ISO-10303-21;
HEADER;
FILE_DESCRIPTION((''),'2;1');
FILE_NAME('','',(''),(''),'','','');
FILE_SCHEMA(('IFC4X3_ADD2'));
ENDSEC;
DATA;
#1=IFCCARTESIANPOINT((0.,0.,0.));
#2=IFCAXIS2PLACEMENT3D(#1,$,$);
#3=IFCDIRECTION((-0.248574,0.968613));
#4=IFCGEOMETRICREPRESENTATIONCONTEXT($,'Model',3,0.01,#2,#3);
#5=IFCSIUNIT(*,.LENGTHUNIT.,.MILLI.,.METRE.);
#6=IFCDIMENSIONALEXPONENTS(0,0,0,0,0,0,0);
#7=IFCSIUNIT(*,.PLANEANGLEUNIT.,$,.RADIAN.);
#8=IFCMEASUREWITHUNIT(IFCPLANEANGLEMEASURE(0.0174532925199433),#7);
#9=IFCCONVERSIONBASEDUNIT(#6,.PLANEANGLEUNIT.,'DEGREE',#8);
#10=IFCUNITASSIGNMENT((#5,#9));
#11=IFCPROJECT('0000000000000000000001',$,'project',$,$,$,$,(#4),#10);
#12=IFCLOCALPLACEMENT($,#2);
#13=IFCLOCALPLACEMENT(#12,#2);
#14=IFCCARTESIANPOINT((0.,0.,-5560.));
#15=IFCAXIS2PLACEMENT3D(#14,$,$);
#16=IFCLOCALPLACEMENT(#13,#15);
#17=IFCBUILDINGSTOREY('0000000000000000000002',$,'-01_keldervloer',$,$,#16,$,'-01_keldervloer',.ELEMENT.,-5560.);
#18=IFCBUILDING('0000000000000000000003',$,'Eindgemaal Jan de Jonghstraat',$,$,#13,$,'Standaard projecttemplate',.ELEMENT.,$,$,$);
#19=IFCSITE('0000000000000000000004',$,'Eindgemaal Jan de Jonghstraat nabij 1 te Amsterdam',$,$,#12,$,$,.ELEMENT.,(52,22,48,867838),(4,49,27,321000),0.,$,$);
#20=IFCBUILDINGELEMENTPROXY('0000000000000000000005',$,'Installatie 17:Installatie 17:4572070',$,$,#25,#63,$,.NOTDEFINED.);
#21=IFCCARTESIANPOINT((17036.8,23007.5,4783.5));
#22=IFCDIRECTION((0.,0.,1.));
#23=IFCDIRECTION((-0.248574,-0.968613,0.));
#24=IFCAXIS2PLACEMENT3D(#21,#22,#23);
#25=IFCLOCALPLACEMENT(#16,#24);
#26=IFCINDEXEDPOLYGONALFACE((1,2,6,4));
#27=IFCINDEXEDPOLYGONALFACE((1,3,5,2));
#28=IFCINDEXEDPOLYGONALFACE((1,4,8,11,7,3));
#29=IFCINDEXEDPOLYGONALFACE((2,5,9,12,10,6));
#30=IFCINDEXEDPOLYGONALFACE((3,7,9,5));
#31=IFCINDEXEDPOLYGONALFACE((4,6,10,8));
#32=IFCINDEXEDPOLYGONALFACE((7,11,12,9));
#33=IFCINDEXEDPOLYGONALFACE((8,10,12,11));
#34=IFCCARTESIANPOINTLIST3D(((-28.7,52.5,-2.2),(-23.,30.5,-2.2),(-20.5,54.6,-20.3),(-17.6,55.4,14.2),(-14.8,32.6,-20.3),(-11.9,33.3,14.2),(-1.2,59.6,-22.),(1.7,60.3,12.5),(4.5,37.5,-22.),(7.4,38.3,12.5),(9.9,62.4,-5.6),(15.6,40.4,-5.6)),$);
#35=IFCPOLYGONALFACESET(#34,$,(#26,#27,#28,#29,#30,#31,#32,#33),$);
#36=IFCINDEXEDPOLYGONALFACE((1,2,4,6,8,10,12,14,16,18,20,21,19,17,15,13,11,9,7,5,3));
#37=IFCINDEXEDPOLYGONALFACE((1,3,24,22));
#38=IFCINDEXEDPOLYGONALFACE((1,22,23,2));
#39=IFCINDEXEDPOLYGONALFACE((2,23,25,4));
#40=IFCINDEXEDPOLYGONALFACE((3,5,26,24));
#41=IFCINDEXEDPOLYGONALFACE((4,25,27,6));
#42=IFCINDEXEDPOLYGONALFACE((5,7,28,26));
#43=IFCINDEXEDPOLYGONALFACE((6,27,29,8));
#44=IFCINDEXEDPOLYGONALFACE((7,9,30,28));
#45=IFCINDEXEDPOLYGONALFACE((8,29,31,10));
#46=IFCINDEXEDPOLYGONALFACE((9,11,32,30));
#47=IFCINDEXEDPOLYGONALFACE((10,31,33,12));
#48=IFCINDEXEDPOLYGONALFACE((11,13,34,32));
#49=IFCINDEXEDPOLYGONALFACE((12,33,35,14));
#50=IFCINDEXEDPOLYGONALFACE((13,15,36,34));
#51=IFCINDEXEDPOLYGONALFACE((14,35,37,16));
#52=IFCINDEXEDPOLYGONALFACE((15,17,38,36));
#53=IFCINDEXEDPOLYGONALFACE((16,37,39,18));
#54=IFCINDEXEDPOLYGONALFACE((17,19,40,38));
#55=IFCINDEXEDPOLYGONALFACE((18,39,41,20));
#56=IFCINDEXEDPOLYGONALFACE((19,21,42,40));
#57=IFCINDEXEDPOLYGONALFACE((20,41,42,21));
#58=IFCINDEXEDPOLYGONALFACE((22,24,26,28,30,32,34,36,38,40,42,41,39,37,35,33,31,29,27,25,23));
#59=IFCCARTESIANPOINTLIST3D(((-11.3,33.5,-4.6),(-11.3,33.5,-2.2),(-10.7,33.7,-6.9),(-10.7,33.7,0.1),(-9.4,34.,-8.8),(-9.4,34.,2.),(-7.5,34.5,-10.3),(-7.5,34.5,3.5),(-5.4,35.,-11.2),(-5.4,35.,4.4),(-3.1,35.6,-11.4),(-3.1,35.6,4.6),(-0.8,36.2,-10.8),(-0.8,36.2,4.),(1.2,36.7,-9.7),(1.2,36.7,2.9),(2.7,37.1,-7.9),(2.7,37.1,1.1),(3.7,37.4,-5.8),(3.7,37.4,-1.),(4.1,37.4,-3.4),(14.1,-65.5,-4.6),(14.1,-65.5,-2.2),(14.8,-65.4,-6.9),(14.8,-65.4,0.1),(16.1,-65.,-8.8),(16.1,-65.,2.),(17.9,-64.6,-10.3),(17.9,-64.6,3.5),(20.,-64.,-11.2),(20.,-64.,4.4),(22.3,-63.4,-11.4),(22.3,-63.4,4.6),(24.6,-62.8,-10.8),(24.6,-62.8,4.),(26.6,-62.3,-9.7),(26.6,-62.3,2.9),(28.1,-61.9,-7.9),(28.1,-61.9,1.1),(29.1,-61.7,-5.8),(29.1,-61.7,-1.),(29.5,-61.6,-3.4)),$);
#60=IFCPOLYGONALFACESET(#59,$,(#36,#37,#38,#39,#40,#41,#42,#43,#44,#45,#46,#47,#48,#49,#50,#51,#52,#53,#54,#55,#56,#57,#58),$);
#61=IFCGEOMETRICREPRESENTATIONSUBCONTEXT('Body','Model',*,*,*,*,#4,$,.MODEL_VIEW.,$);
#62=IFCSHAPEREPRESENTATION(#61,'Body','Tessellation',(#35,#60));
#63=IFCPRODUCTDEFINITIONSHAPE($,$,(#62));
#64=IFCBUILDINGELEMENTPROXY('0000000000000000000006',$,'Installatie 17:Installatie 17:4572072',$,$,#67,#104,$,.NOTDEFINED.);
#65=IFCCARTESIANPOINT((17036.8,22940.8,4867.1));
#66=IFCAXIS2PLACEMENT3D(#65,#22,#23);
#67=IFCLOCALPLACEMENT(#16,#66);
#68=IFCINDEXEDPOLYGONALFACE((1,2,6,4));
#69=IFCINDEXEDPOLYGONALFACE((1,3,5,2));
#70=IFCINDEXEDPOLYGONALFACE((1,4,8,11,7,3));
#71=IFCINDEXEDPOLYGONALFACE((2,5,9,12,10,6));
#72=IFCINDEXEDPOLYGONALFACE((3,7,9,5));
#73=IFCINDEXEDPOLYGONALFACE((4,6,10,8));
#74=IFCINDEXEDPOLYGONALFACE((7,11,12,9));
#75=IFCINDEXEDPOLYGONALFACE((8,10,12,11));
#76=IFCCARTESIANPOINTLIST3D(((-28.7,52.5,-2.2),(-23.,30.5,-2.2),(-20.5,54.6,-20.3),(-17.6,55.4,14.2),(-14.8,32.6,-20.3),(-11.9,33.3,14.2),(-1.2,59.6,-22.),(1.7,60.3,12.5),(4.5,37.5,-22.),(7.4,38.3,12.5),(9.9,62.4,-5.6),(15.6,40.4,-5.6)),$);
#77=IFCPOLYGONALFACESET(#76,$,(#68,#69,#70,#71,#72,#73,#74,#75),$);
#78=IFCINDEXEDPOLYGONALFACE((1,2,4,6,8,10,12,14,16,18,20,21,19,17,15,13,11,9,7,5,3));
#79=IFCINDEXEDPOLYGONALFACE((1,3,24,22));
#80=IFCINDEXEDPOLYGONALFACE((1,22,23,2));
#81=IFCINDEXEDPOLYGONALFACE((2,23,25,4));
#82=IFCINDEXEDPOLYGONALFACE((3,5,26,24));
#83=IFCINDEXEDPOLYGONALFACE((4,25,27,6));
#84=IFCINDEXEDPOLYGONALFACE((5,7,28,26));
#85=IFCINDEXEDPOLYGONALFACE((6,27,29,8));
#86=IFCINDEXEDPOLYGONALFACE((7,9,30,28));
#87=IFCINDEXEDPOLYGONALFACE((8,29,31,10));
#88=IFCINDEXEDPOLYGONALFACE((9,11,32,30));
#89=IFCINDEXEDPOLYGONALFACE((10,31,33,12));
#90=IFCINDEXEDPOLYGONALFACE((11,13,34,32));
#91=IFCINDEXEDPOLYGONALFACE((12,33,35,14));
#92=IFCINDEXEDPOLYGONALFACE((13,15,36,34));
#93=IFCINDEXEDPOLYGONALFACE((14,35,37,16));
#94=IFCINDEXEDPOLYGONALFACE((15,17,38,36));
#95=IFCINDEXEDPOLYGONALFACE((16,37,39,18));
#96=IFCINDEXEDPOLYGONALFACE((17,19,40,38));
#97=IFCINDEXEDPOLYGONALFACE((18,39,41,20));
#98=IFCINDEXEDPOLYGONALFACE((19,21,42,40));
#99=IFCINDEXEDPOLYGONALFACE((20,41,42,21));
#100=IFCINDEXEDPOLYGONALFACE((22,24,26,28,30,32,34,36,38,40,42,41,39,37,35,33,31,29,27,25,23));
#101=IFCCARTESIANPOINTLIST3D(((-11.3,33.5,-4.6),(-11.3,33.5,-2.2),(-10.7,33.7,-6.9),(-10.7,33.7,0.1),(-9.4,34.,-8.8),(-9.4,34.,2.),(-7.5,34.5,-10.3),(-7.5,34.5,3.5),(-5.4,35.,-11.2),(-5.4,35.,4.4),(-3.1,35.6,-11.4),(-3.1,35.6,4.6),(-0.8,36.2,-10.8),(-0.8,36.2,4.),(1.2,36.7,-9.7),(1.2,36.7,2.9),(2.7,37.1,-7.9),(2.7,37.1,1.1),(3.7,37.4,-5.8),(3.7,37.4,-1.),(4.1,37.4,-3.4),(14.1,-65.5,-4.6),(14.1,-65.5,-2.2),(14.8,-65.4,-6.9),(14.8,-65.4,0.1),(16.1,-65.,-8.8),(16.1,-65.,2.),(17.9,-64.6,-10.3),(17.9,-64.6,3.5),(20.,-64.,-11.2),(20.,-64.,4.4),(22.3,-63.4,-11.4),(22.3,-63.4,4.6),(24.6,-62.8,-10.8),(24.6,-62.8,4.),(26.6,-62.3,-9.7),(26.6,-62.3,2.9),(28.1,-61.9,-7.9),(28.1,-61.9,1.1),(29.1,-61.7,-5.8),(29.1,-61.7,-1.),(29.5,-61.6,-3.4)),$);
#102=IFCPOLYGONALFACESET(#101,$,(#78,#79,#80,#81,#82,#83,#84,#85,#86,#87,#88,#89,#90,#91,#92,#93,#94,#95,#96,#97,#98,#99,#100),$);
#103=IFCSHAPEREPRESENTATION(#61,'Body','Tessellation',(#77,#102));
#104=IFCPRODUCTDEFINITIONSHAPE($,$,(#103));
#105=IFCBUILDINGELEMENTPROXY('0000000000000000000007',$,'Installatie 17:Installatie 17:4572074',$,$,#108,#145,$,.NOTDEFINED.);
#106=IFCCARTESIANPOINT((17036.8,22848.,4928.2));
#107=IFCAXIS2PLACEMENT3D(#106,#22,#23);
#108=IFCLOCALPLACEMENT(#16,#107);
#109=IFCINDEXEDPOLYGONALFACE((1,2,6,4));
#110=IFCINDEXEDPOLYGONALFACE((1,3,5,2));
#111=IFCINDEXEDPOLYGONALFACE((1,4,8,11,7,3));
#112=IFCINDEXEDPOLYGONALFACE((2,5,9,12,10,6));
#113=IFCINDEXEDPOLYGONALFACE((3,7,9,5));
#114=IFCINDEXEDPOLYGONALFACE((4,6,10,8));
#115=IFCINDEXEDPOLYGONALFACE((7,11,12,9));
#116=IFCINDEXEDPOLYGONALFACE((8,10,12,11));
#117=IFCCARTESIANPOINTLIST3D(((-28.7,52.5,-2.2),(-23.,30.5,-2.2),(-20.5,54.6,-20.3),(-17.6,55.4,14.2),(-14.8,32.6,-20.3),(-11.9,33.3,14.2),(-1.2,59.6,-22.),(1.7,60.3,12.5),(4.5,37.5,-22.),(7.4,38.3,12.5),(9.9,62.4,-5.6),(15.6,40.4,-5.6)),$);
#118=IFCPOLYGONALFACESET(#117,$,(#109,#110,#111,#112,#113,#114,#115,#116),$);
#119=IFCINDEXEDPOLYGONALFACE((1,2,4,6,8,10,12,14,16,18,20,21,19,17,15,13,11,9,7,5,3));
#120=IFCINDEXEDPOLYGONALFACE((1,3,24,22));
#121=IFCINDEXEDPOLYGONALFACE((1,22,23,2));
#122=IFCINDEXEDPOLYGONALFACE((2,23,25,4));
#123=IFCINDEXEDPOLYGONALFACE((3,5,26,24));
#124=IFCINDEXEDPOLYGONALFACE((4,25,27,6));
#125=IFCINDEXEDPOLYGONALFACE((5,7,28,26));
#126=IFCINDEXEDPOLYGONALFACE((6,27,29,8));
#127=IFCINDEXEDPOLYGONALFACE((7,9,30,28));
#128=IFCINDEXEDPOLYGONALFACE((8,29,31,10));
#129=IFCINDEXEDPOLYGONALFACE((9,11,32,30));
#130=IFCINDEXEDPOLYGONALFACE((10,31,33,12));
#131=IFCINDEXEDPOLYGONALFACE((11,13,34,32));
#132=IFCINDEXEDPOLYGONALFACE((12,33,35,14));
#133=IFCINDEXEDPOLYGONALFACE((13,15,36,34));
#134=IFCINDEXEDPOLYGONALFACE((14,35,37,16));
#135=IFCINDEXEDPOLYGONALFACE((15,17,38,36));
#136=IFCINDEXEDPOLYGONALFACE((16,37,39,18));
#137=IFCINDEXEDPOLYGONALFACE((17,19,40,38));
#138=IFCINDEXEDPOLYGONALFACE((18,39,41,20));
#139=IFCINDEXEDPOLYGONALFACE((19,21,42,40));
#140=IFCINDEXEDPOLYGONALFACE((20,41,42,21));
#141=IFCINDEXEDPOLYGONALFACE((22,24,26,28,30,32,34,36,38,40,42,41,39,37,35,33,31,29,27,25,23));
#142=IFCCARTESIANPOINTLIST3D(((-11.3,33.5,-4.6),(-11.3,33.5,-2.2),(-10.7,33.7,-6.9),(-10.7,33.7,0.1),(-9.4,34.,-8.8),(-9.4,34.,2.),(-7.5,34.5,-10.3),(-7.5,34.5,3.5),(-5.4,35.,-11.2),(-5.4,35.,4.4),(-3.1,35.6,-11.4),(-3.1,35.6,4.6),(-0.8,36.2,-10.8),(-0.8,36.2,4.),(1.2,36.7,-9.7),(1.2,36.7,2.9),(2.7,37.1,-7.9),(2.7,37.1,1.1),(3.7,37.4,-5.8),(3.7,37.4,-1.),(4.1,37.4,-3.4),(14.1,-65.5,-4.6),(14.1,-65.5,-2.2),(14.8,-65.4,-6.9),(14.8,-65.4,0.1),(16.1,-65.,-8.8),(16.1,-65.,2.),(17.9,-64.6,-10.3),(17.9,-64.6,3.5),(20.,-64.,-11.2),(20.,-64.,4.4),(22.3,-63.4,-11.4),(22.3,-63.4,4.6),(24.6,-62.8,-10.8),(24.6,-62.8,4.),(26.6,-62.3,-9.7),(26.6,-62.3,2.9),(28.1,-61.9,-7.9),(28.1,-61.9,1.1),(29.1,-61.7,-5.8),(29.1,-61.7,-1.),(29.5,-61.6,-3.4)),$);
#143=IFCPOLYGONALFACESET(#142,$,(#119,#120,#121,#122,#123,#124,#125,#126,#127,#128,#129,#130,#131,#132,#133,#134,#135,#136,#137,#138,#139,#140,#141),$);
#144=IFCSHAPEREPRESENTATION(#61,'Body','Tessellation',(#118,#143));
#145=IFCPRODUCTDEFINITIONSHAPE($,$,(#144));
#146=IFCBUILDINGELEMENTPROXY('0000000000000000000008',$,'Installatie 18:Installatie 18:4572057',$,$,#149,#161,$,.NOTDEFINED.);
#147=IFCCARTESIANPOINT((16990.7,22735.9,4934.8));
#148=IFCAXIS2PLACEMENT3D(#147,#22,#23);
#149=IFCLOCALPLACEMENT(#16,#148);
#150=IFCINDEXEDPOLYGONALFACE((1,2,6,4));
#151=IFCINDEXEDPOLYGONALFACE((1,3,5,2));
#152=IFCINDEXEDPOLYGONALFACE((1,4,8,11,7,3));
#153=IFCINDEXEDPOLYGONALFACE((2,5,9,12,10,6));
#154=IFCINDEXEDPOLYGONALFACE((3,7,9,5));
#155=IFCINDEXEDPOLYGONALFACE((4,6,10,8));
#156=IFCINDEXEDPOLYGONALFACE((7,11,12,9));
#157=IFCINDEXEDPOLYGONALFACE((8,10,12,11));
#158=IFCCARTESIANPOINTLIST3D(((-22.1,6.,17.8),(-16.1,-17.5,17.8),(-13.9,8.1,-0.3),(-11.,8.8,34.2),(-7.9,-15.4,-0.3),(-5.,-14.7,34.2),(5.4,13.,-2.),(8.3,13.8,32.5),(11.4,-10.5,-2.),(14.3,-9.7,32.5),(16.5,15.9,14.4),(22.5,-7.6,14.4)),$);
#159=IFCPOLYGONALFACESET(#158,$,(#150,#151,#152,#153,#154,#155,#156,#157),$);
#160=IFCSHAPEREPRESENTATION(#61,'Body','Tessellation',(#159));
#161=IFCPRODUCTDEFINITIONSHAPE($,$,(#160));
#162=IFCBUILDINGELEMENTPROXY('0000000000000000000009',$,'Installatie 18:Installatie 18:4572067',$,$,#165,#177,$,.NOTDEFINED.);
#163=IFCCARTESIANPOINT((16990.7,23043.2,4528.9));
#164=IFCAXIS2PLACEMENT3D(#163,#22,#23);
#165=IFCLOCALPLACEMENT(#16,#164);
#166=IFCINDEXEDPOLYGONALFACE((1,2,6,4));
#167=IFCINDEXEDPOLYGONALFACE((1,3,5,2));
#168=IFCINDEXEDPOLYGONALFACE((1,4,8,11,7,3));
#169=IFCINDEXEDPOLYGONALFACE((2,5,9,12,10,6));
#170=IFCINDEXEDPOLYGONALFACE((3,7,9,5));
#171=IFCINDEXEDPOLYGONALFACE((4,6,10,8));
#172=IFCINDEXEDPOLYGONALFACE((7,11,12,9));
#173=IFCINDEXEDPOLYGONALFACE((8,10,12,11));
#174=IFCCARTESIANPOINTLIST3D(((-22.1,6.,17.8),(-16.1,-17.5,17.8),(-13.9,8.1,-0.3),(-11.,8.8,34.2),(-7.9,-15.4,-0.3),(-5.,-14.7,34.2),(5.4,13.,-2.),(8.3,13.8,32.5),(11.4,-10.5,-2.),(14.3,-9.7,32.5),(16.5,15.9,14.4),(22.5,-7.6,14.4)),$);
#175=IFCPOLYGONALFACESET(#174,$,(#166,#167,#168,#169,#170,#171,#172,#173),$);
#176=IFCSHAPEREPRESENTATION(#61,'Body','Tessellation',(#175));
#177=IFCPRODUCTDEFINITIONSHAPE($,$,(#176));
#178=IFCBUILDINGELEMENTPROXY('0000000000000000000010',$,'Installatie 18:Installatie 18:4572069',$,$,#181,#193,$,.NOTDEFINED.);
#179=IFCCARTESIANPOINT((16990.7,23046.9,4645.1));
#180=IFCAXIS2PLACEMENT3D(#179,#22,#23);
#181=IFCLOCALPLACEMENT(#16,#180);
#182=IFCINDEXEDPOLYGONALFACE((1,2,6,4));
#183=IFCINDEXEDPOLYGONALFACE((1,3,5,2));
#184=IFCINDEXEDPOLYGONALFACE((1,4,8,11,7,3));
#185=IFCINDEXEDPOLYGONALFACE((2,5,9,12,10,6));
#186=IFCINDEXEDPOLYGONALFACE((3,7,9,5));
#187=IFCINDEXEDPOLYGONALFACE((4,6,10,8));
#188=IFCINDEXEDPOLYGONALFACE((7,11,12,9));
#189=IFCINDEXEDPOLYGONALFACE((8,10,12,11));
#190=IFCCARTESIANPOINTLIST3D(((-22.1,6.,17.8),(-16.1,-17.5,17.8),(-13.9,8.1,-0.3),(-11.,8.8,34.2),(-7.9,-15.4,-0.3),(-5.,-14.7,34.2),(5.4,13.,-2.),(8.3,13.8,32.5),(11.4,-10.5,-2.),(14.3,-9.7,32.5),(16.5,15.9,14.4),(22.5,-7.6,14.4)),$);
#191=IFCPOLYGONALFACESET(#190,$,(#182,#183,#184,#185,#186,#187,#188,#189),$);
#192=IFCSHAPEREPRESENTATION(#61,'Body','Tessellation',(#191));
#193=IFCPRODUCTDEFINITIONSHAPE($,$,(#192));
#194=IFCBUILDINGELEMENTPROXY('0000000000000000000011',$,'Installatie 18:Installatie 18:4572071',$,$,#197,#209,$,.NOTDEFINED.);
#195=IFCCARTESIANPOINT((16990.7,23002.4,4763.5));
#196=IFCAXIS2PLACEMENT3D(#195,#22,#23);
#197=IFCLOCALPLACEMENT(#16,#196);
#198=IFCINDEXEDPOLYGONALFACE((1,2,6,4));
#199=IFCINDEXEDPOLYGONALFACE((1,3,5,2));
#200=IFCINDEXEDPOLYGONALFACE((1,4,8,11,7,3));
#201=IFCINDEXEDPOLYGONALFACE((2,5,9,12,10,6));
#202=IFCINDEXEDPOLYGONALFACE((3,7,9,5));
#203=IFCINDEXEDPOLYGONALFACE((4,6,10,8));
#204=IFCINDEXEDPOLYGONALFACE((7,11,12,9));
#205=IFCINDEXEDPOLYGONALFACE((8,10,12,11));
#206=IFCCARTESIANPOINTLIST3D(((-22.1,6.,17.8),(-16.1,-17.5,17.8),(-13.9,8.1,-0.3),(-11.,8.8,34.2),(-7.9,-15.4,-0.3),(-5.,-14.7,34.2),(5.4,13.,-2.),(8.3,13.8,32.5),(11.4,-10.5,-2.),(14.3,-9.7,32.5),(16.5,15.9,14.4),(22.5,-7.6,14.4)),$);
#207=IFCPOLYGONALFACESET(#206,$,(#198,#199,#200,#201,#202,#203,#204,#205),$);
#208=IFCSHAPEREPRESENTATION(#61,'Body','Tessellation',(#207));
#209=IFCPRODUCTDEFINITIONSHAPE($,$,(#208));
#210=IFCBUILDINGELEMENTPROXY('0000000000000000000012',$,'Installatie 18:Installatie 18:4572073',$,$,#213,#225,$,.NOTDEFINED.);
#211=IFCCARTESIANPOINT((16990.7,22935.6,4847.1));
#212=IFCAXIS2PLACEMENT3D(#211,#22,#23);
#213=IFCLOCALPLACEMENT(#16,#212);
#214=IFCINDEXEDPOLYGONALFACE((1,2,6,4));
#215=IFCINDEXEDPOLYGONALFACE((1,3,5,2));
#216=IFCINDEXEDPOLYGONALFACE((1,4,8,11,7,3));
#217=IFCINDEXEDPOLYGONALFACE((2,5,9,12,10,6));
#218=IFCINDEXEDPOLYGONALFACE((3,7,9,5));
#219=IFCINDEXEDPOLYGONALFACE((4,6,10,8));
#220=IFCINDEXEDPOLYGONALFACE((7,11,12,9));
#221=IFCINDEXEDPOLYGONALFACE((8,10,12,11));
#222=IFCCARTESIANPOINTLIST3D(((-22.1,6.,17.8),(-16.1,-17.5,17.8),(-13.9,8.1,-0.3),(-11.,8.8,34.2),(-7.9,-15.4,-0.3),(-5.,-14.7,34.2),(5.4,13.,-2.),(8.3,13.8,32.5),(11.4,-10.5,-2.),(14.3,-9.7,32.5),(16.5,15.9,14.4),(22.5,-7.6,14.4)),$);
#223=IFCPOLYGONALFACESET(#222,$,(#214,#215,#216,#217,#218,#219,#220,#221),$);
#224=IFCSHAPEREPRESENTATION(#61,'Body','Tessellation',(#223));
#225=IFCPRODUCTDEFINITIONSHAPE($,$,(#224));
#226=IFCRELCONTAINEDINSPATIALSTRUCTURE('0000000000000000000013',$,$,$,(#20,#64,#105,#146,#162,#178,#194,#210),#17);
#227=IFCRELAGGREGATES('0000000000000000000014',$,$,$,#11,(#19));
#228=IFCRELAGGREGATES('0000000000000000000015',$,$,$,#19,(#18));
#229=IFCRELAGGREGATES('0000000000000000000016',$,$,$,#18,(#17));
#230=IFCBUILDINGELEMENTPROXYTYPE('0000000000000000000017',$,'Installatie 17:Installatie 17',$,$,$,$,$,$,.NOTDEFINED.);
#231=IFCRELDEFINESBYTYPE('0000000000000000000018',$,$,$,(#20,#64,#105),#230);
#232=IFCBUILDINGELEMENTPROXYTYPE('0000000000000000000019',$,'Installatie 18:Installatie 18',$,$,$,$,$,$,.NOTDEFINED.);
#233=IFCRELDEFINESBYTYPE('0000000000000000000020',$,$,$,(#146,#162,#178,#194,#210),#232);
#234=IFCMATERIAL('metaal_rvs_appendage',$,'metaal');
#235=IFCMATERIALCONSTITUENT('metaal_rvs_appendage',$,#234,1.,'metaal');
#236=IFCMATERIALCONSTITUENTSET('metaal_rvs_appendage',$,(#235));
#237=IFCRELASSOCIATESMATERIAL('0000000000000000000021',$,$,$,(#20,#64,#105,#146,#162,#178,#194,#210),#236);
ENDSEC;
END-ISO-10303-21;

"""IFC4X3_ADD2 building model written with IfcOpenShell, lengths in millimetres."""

from ifc_helpers import new_model, entity, si_unit, converted_unit, direction, frame, frame_2d, origin, place, context, subcontext, project, spatial, polyline, circle, outline, extrude, source, transform, mapped, material, constituent, constituent_set, type_object, type_shapes, element, save


model = new_model("IFC4X3_ADD2")

# Units and contexts
model_context = context("Model", 3, precision=0.01, world=origin(), true_north=direction((-0.248574, 0.968613)))
body_context = subcontext(model_context, "Body", "Model", "MODEL_VIEW")
ifc_project = project(units=[si_unit("LENGTHUNIT", "METRE", prefix="MILLI"), converted_unit("PLANEANGLEUNIT", "DEGREE", entity("IfcPlaneAngleMeasure", 0.0174532925199433), si_unit("PLANEANGLEUNIT", "RADIAN"), dimensions=[0, 0, 0, 0, 0, 0, 0])], contexts=[model_context])

# Site, building, storey
site_placement = place(None, origin())
site = spatial("IfcSite", under=ifc_project, at=site_placement, Name="Eindgemaal Jan de Jonghstraat nabij 1 te Amsterdam", CompositionType="ELEMENT", RefLatitude=(52, 22, 48, 867838), RefLongitude=(4, 49, 27, 321000), RefElevation=0.0)
building_placement = place(site_placement, origin())
building = spatial("IfcBuilding", under=site, at=building_placement, Name="Eindgemaal Jan de Jonghstraat", LongName="Standaard projecttemplate", CompositionType="ELEMENT")
storey_placement = place(building_placement, frame((0.0, 0.0, -5560.0)))
storey = spatial("IfcBuildingStorey", under=building, at=storey_placement, Name="-01_keldervloer", LongName="-01_keldervloer", CompositionType="ELEMENT", Elevation=-5560.0)

# Building element proxies
ifc_material_1 = material(Name="metaal_rvs_appendage", Category="metaal")
ifc_constituent_1 = constituent(ifc_material_1, Name="metaal_rvs_appendage", Category="metaal", fraction=1.0)
ifc_constituent_set_1 = constituent_set(constituents=[ifc_constituent_1], Name="metaal_rvs_appendage")
building_element_proxy_type_1 = type_object("IfcBuildingElementProxyType", Name="Installatie 17:Installatie 17", PredefinedType="NOTDEFINED")
shared_shape_1 = source(origin(), body_context, "Body", "SweptSolid", [
    extrude(outline(polyline([(-10.0, -17.3), (10.0, -17.3), (20.0, 0.0), (10.0, 17.3), (-10.0, 17.3), (-20.0, 0.0), (-10.0, -17.3)])), frame((-3.7, 35.4, -3.9), z_axis=(-0.248574, 0.968613, 0.0), x_axis=(-0.555573, -0.142576, -0.819152)), (0.0, 0.0, 1.0), 22.8),
    extrude(circle(Radius=8.0, at=frame_2d((0.0, 0.0), x_axis=(1.0, 0.0))), frame((21.7, -63.6, -3.4), z_axis=(-0.248574, 0.968613, 0.0), x_axis=(0.968613, 0.248574, 0.0)), (0.0, 0.0, 1.0), 102.2),
])
type_shapes(building_element_proxy_type_1, [shared_shape_1])
for number, where, z_axis, x_axis, name in (
    (1, (17036.8, 23007.5, 4783.5), (0.0, 0.0, 1.0), (-0.248574, -0.968613, 0.0), "Installatie 17:Installatie 17:4572070"),
    (2, (17036.8, 22940.8, 4867.1), (0.0, 0.0, 1.0), (-0.248574, -0.968613, 0.0), "Installatie 17:Installatie 17:4572072"),
    (3, (17036.8, 22848.0, 4928.2), (0.0, 0.0, 1.0), (-0.248574, -0.968613, 0.0), "Installatie 17:Installatie 17:4572074"),
):
    element("IfcBuildingElementProxy", number, at=place(storey_placement, frame(where, z_axis=z_axis, x_axis=x_axis)), inside=storey, type_object=building_element_proxy_type_1, material=ifc_constituent_set_1, Name=name, PredefinedType="NOTDEFINED", context=body_context, shape_type="MappedRepresentation", body=[
        mapped(shared_shape_1, transform((0.0, 0.0, 0.0), scale=1.0)),
    ])
building_element_proxy_type_2 = type_object("IfcBuildingElementProxyType", Name="Installatie 18:Installatie 18", PredefinedType="NOTDEFINED")
shared_shape_2 = source(origin(), body_context, "Body", "SweptSolid", [
    extrude(outline(polyline([(-10.0, -17.3), (10.0, -17.3), (20.0, 0.0), (10.0, 17.3), (-10.0, 17.3), (-20.0, 0.0), (-10.0, -17.3)])), frame((3.2, -12.6, 16.1), z_axis=(-0.248574, 0.968613, 0.0), x_axis=(0.409353, 0.105052, -0.906308)), (0.0, 0.0, 1.0), 24.3),
])
type_shapes(building_element_proxy_type_2, [shared_shape_2])
for number, where, z_axis, x_axis, name in (
    (4, (16990.7, 22735.9, 4934.8), (0.0, 0.0, 1.0), (-0.248574, -0.968613, 0.0), "Installatie 18:Installatie 18:4572057"),
    (5, (16990.7, 23043.2, 4528.9), (0.0, 0.0, 1.0), (-0.248574, -0.968613, 0.0), "Installatie 18:Installatie 18:4572067"),
    (6, (16990.7, 23046.9, 4645.1), (0.0, 0.0, 1.0), (-0.248574, -0.968613, 0.0), "Installatie 18:Installatie 18:4572069"),
    (7, (16990.7, 23002.4, 4763.5), (0.0, 0.0, 1.0), (-0.248574, -0.968613, 0.0), "Installatie 18:Installatie 18:4572071"),
    (8, (16990.7, 22935.6, 4847.1), (0.0, 0.0, 1.0), (-0.248574, -0.968613, 0.0), "Installatie 18:Installatie 18:4572073"),
):
    element("IfcBuildingElementProxy", number, at=place(storey_placement, frame(where, z_axis=z_axis, x_axis=x_axis)), inside=storey, type_object=building_element_proxy_type_2, material=ifc_constituent_set_1, Name=name, PredefinedType="NOTDEFINED", context=body_context, shape_type="MappedRepresentation", body=[
        mapped(shared_shape_2, transform((0.0, 0.0, 0.0), scale=1.0)),
    ])

save(model, "model.ifc")
